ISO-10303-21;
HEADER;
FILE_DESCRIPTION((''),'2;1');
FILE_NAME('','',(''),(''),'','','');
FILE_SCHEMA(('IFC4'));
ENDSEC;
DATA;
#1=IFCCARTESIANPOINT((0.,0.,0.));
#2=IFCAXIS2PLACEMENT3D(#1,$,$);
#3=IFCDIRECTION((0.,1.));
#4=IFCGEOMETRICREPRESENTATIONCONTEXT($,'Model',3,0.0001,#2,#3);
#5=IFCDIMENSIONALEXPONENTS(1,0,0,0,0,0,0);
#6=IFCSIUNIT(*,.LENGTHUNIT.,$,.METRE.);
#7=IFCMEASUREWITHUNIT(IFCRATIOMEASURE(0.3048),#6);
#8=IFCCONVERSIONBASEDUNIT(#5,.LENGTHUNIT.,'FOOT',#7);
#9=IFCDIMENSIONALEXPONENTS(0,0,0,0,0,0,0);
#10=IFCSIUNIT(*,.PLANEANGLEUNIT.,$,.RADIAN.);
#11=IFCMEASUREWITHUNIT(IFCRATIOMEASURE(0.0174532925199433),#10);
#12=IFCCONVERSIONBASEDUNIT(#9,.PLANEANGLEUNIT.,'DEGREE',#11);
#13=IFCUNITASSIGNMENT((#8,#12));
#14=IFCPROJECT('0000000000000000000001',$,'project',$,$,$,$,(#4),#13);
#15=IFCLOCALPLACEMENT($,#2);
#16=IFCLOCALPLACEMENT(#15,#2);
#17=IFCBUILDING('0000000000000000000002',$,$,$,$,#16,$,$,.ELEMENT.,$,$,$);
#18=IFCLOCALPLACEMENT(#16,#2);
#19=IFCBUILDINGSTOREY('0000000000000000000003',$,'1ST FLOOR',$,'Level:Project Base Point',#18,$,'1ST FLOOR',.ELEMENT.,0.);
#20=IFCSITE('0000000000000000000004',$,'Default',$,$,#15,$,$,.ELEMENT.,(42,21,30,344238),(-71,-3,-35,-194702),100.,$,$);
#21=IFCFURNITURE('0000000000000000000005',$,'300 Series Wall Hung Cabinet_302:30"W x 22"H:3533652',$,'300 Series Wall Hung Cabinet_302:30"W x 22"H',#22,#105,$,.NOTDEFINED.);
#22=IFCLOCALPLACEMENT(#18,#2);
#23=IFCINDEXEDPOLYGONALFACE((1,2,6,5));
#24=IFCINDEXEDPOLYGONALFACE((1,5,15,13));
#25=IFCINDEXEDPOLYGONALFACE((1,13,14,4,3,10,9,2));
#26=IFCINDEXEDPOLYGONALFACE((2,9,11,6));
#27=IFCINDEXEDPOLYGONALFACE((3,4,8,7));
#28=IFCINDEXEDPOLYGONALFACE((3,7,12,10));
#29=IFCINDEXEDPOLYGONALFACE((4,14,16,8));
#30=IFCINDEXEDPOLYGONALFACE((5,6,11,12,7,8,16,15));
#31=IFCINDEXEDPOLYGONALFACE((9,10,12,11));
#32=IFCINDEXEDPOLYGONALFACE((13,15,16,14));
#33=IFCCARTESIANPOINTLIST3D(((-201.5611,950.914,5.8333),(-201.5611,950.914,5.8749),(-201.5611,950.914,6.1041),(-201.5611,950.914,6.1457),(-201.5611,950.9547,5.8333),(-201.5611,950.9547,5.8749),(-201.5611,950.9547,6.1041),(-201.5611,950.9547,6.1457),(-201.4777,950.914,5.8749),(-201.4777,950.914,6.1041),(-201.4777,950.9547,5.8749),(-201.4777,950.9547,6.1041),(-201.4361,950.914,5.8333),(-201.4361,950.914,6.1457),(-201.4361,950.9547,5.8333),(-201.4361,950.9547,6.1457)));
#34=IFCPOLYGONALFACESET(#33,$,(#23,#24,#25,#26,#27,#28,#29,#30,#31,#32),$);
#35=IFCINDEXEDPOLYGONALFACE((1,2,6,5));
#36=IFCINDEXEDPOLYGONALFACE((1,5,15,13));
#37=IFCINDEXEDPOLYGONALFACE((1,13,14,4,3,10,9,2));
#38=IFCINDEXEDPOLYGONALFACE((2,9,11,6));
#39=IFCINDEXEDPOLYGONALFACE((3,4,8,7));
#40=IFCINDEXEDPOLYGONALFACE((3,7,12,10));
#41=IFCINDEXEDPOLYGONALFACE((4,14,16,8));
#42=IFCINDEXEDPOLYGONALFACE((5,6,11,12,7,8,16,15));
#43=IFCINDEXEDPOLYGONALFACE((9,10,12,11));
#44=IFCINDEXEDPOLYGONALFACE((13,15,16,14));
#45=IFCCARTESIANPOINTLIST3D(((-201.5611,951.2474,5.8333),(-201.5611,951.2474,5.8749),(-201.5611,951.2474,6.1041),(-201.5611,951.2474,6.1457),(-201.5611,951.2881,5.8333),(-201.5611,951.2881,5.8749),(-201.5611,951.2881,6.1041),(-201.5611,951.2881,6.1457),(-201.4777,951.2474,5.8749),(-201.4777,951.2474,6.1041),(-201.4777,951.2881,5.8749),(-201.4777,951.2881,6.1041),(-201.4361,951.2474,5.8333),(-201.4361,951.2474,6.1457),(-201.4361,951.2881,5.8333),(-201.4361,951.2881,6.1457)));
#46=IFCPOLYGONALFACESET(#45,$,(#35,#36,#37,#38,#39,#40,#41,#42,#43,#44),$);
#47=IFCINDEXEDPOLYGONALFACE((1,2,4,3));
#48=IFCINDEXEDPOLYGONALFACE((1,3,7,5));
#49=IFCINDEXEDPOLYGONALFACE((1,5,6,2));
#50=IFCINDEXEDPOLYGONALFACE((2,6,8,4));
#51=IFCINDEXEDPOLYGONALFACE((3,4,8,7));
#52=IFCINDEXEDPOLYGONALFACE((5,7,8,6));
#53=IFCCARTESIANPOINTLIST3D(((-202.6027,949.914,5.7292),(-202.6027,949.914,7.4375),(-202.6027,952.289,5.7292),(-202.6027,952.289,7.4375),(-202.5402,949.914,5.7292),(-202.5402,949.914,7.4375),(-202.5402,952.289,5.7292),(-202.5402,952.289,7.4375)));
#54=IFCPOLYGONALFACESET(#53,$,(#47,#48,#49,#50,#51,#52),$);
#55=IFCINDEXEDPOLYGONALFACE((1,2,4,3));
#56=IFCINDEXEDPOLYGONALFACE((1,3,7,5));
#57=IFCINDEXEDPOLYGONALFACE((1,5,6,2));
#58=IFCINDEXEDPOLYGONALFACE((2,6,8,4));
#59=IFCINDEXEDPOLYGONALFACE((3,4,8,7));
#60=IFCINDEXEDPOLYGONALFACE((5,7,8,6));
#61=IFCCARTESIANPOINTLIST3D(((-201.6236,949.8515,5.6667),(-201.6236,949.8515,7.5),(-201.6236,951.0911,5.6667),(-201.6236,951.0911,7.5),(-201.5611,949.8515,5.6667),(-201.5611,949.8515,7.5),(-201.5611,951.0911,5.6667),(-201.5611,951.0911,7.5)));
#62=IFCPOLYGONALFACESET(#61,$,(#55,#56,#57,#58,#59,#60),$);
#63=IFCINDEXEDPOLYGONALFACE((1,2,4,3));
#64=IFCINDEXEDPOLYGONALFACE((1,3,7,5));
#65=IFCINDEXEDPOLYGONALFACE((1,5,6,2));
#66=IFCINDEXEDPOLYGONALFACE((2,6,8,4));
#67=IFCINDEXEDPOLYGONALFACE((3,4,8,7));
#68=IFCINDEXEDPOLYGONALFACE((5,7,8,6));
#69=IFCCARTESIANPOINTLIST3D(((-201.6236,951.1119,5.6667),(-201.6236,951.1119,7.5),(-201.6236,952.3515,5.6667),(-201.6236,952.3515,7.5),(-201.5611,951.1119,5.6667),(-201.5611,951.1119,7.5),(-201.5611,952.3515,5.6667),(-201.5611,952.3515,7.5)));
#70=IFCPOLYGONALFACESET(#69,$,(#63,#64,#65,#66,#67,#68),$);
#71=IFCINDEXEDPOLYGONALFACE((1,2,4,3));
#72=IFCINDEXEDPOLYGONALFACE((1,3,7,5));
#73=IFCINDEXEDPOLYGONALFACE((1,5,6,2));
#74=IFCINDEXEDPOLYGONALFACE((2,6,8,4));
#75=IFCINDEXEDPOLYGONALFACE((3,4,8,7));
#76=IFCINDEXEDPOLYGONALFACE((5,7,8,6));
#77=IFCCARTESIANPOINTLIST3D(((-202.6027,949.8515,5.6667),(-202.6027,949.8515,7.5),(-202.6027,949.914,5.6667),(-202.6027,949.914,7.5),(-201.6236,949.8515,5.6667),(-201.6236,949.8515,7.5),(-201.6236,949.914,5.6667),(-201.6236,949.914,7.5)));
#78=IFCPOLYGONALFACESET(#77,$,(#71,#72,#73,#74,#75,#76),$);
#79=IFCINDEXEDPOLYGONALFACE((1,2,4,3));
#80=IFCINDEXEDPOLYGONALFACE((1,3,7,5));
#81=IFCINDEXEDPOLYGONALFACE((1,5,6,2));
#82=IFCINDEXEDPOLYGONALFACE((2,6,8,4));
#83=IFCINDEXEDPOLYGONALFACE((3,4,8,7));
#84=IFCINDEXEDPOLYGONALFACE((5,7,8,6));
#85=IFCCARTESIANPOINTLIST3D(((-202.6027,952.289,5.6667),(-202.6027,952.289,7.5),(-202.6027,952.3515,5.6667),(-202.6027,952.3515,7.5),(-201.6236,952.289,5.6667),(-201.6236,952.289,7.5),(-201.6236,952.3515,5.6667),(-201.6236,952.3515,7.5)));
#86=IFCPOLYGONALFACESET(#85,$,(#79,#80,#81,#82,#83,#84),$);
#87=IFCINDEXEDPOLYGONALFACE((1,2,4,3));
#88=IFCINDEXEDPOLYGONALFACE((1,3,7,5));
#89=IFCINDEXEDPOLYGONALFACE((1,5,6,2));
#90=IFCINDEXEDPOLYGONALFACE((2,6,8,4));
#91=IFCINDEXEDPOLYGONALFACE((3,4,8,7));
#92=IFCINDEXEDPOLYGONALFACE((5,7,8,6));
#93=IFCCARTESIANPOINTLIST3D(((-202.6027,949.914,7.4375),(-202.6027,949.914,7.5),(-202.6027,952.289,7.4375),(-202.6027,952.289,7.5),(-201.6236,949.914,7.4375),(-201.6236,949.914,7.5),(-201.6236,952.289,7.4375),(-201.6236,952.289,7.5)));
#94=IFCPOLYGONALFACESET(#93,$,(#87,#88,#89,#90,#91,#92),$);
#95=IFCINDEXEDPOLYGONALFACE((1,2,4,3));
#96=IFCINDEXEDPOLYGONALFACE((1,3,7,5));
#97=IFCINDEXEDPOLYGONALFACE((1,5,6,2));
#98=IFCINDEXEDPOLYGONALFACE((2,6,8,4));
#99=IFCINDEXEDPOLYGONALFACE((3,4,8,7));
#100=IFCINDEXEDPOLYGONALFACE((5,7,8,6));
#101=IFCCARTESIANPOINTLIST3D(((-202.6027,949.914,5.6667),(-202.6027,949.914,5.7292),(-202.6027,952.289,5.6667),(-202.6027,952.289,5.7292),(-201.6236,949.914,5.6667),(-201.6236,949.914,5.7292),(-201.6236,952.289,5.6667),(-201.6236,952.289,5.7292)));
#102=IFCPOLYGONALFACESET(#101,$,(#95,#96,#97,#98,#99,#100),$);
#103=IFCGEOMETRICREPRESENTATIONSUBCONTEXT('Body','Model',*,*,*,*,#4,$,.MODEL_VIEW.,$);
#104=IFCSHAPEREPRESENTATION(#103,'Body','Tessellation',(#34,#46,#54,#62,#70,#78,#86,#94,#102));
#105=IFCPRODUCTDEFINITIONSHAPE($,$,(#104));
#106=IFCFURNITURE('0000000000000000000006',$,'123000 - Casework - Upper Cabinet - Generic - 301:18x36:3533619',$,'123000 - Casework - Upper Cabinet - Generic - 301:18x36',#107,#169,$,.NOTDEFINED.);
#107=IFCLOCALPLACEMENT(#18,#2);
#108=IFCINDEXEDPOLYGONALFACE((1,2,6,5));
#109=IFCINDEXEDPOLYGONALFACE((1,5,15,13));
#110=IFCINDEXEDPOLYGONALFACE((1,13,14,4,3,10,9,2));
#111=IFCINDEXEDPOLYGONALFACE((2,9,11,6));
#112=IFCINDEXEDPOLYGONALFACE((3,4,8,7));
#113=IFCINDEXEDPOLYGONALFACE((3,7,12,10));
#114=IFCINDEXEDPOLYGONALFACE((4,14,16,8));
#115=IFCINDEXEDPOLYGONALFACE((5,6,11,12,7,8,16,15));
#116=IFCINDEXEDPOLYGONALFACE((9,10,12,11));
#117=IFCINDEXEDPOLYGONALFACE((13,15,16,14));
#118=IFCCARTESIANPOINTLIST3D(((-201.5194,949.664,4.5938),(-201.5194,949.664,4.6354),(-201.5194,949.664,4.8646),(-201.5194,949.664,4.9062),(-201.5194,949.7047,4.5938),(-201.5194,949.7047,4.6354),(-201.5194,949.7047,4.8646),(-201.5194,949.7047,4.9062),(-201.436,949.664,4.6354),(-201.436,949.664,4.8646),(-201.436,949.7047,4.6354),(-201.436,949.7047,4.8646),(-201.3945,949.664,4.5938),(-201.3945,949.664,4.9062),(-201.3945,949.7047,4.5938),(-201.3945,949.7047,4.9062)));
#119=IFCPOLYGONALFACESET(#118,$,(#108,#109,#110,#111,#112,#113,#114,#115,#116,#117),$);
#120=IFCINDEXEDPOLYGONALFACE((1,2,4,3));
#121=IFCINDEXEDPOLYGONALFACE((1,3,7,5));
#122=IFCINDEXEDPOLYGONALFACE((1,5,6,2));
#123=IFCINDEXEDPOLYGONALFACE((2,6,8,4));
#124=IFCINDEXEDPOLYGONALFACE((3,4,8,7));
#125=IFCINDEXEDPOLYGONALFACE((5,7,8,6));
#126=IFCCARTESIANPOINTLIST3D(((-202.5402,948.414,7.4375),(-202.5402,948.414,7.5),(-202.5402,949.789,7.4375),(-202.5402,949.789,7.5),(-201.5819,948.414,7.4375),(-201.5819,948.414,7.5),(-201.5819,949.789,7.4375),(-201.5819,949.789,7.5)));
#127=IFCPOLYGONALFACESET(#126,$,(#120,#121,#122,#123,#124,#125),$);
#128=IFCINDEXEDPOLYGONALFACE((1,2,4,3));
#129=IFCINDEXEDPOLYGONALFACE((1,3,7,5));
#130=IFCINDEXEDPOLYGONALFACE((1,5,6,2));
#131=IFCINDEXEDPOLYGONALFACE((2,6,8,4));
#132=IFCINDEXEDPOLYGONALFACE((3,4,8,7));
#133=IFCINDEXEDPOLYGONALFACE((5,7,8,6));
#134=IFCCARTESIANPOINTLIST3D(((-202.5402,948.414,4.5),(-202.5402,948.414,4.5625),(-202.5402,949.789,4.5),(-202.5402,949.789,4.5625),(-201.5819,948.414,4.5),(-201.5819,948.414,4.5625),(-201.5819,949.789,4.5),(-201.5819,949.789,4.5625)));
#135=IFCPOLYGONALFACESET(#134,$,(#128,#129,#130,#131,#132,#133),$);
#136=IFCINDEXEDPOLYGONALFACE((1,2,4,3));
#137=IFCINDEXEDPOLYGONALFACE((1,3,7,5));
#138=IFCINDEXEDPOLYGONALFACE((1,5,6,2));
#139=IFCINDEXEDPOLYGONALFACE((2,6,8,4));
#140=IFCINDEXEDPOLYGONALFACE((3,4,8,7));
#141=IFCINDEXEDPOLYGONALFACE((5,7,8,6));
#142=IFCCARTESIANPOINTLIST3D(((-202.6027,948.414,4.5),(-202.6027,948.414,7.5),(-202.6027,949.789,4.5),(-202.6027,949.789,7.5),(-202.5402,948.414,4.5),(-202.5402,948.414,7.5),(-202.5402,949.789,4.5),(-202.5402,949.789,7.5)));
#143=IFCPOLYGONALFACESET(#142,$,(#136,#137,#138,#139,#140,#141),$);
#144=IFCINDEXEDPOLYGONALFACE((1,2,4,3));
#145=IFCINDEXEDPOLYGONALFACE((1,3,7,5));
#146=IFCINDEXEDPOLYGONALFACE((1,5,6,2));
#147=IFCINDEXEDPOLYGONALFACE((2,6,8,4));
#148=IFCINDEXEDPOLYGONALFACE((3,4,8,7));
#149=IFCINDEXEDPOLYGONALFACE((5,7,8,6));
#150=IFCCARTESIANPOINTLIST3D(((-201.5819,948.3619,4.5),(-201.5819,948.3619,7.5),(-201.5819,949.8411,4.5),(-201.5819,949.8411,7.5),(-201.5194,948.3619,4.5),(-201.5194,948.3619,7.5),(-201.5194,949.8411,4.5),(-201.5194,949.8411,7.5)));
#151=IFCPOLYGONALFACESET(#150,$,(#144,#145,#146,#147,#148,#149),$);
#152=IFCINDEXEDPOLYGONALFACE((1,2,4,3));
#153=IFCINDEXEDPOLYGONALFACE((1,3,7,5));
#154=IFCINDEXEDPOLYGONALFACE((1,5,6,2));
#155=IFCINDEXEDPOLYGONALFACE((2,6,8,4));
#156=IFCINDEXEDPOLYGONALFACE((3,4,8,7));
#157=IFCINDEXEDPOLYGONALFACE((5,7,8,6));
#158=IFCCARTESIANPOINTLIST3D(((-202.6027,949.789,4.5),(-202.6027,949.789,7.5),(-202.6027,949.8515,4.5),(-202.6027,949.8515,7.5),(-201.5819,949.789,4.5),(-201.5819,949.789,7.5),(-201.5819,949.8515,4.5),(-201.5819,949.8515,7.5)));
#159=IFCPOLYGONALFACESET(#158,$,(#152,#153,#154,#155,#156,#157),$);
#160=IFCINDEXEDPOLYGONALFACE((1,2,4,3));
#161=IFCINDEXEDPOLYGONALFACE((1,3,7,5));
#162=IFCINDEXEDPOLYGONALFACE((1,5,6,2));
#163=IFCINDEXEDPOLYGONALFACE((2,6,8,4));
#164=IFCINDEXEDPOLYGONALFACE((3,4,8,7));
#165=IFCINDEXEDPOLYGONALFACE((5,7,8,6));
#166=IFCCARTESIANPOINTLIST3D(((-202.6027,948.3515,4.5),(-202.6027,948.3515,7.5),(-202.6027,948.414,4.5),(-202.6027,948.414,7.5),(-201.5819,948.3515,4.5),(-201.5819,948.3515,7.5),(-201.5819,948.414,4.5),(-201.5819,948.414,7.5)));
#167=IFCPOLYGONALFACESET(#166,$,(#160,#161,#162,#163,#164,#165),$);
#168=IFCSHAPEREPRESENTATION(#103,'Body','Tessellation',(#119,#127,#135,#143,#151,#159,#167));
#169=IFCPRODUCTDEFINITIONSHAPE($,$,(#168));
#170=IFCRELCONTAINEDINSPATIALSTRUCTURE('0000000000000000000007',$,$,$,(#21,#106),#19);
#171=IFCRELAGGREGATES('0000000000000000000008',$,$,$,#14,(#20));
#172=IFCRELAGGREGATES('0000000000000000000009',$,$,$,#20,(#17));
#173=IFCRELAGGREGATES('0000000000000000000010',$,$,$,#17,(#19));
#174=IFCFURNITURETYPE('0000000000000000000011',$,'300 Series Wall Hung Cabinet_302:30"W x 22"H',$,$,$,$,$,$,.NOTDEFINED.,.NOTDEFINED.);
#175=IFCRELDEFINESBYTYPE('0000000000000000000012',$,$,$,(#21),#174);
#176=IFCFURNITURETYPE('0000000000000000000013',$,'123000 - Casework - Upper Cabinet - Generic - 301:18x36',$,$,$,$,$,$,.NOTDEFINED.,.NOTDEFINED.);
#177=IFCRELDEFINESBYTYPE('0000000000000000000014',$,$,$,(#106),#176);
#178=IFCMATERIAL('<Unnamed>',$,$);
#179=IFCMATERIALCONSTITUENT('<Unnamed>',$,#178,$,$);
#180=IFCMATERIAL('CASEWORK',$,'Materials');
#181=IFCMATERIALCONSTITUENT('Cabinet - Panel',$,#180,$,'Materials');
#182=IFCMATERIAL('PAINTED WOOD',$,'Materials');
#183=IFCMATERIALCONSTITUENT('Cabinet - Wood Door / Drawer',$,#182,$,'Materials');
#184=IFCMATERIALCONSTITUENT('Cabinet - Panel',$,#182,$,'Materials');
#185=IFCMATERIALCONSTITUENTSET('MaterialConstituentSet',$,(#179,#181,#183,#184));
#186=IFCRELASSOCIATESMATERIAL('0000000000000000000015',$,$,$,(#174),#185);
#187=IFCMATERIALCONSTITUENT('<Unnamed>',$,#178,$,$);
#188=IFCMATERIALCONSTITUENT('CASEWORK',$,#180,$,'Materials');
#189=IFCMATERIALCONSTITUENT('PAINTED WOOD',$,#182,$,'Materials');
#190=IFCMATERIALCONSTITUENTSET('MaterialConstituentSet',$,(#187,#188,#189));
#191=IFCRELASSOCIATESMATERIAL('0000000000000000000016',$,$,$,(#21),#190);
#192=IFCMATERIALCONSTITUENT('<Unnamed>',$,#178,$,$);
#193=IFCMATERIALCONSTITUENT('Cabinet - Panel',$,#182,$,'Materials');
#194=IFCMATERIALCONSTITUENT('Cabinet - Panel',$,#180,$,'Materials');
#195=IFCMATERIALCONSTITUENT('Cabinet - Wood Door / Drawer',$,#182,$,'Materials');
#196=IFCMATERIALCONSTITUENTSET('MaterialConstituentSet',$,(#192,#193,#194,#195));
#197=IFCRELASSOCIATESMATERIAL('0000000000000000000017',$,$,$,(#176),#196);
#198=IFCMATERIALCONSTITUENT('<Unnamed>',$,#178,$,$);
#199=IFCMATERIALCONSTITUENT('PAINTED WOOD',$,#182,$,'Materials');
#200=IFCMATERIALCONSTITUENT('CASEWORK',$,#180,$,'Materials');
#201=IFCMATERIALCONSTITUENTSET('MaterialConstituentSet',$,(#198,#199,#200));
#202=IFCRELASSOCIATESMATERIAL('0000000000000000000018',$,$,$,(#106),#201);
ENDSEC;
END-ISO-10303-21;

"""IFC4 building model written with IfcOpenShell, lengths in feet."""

from ifc_helpers import new_model, entity, si_unit, converted_unit, direction, frame, frame_2d, origin, origin_2d_with_axis, place, context, subcontext, project, spatial, polyline, rectangle, outline, extrude, source, transform, mapped, material, constituent, constituent_set, type_object, type_shapes, element, save


model = new_model("IFC4")

# Units and contexts
model_context = context("Model", 3, precision=0.0001, world=origin(), true_north=direction((0.0, 1.0)))
body_context = subcontext(model_context, "Body", "Model", "MODEL_VIEW")
ifc_project = project(units=[converted_unit("LENGTHUNIT", "FOOT", entity("IfcRatioMeasure", 0.3048), si_unit("LENGTHUNIT", "METRE"), dimensions=[1, 0, 0, 0, 0, 0, 0]), converted_unit("PLANEANGLEUNIT", "DEGREE", entity("IfcRatioMeasure", 0.0174532925199433), si_unit("PLANEANGLEUNIT", "RADIAN"), dimensions=[0, 0, 0, 0, 0, 0, 0])], contexts=[model_context])

# Site, building, storey
site_placement = place(None, origin())
site = spatial("IfcSite", under=ifc_project, at=site_placement, Name="Default", CompositionType="ELEMENT", RefLatitude=(42, 21, 30, 344238), RefLongitude=(-71, -3, -35, -194702), RefElevation=100.0)
building_placement = place(site_placement, origin())
building = spatial("IfcBuilding", under=site, at=building_placement, CompositionType="ELEMENT")
storey_placement = place(building_placement, origin())
storey = spatial("IfcBuildingStorey", under=building, at=storey_placement, Name="1ST FLOOR", ObjectType="Level:Project Base Point", LongName="1ST FLOOR", CompositionType="ELEMENT", Elevation=0.0)

# Shared definitions
ifc_material_1 = material(Name="<Unnamed>")

# Shared definitions
ifc_material_2 = material(Name="PAINTED WOOD", Category="Materials")
ifc_material_3 = material(Name="CASEWORK", Category="Materials")

# Furniture
ifc_constituent_1 = constituent(ifc_material_1, Name="<Unnamed>")
ifc_constituent_2 = constituent(ifc_material_3, Name="CASEWORK", Category="Materials")
ifc_constituent_3 = constituent(ifc_material_2, Name="PAINTED WOOD", Category="Materials")
ifc_constituent_set_1 = constituent_set(constituents=[ifc_constituent_1, ifc_constituent_2, ifc_constituent_3], Name="MaterialConstituentSet")
ifc_constituent_4 = constituent(ifc_material_1, Name="<Unnamed>")
ifc_constituent_5 = constituent(ifc_material_3, Name="Cabinet - Panel", Category="Materials")
ifc_constituent_6 = constituent(ifc_material_2, Name="Cabinet - Wood Door / Drawer", Category="Materials")
ifc_constituent_7 = constituent(ifc_material_2, Name="Cabinet - Panel", Category="Materials")
ifc_constituent_set_2 = constituent_set(constituents=[ifc_constituent_4, ifc_constituent_5, ifc_constituent_6, ifc_constituent_7], Name="MaterialConstituentSet")
furniture_type_1 = type_object("IfcFurnitureType", Name="300 Series Wall Hung Cabinet_302:30\"W x 22\"H", AssemblyPlace="NOTDEFINED", PredefinedType="NOTDEFINED", material=ifc_constituent_set_2)
shared_shape_1 = source(origin(), body_context, "Body", "SweptSolid", [
    extrude(outline(polyline([(0.1146, -0.0521), (0.1562, -0.0521), (0.1562, 0.0729), (-0.1562, 0.0729), (-0.1562, -0.0521), (-0.1146, -0.0521), (-0.1146, 0.0313), (0.1146, 0.0313), (0.1146, -0.0521)])), frame((1.0625, 0.0729, 0.3229), z_axis=(1.0, 0.0, 0.0), x_axis=(0.0, 0.0, 1.0)), (0.0, 0.0, 1.0), 0.0407),
    extrude(outline(polyline([(0.1146, -0.0521), (0.1562, -0.0521), (0.1562, 0.0729), (-0.1562, 0.0729), (-0.1562, -0.0521), (-0.1146, -0.0521), (-0.1146, 0.0313), (0.1146, 0.0313), (0.1146, -0.0521)])), frame((1.3958, 0.0729, 0.3229), z_axis=(1.0, 0.0, 0.0), x_axis=(0.0, 0.0, 1.0)), (0.0, 0.0, 1.0), 0.0407),
    extrude(rectangle(XDim=2.375, YDim=0.0625, at=origin_2d_with_axis()), frame((1.25, 1.1354, 0.0625), z_axis=(0.0, 0.0, 1.0), x_axis=(-1.0, 0.0, 0.0)), (0.0, 0.0, 1.0), 1.7083),
    extrude(rectangle(XDim=1.2396, YDim=0.0625, at=origin_2d_with_axis()), frame((0.6198, 0.1562, 0.0), z_axis=(0.0, 0.0, 1.0), x_axis=(-1.0, 0.0, 0.0)), (0.0, 0.0, 1.0), 1.8333),
    extrude(rectangle(XDim=1.2396, YDim=0.0625, at=frame_2d((0.0, 0.0), x_axis=(1.0, 0.0))), frame((1.8802, 0.1562, 0.0), z_axis=(0.0, 0.0, 1.0), x_axis=(-1.0, 0.0, 0.0)), (0.0, 0.0, 1.0), 1.8333),
    extrude(rectangle(XDim=0.9792, YDim=0.0625, at=frame_2d((0.0, 0.0), x_axis=(1.0, 0.0))), frame((0.0313, 0.677, 0.0), z_axis=(0.0, 0.0, 1.0), x_axis=(0.0, -1.0, 0.0)), (0.0, 0.0, 1.0), 1.8333),
    extrude(rectangle(XDim=0.9792, YDim=0.0625, at=frame_2d((0.0, 0.0), x_axis=(1.0, 0.0))), frame((2.4688, 0.677, 0.0), z_axis=(0.0, 0.0, 1.0), x_axis=(0.0, -1.0, 0.0)), (0.0, 0.0, 1.0), 1.8333),
    extrude(rectangle(XDim=0.9792, YDim=2.375, at=frame_2d((0.0, 0.0), x_axis=(1.0, 0.0))), frame((1.25, 0.677, 1.7708), z_axis=(0.0, 0.0, 1.0), x_axis=(0.0, 1.0, 0.0)), (0.0, 0.0, 1.0), 0.0625),
    extrude(rectangle(XDim=0.9792, YDim=2.375, at=frame_2d((0.0, 0.0), x_axis=(1.0, 0.0))), frame((1.25, 0.677, 0.0), z_axis=(0.0, 0.0, 1.0), x_axis=(0.0, 1.0, 0.0)), (0.0, 0.0, 1.0), 0.0625),
])
type_shapes(furniture_type_1, [shared_shape_1])
furniture_1_placement = place(storey_placement, frame((-201.4361, 949.8515, 5.6667), z_axis=(0.0, 0.0, 1.0), x_axis=(0.0, 1.0, 0.0)))
element("IfcFurniture", 1, at=furniture_1_placement, inside=storey, type_object=furniture_type_1, material=ifc_constituent_set_1, Name="300 Series Wall Hung Cabinet_302:30\"W x 22\"H:3533652", ObjectType="300 Series Wall Hung Cabinet_302:30\"W x 22\"H", PredefinedType="NOTDEFINED", context=body_context, shape_type="MappedRepresentation", body=[
    mapped(shared_shape_1, transform((0.0, 0.0, 0.0), scale=1.0)),
])
ifc_constituent_8 = constituent(ifc_material_1, Name="<Unnamed>")
ifc_constituent_9 = constituent(ifc_material_2, Name="PAINTED WOOD", Category="Materials")
ifc_constituent_10 = constituent(ifc_material_3, Name="CASEWORK", Category="Materials")
ifc_constituent_set_3 = constituent_set(constituents=[ifc_constituent_8, ifc_constituent_9, ifc_constituent_10], Name="MaterialConstituentSet")
ifc_constituent_11 = constituent(ifc_material_1, Name="<Unnamed>")
ifc_constituent_12 = constituent(ifc_material_2, Name="Cabinet - Panel", Category="Materials")
ifc_constituent_13 = constituent(ifc_material_3, Name="Cabinet - Panel", Category="Materials")
ifc_constituent_14 = constituent(ifc_material_2, Name="Cabinet - Wood Door / Drawer", Category="Materials")
ifc_constituent_set_4 = constituent_set(constituents=[ifc_constituent_11, ifc_constituent_12, ifc_constituent_13, ifc_constituent_14], Name="MaterialConstituentSet")
furniture_type_2 = type_object("IfcFurnitureType", Name="123000 - Casework - Upper Cabinet - Generic - 301:18x36", AssemblyPlace="NOTDEFINED", PredefinedType="NOTDEFINED", material=ifc_constituent_set_4)
shared_shape_2 = source(origin(), body_context, "Body", "SweptSolid", [
    extrude(outline(polyline([(-0.0521, -0.1146), (-0.0521, -0.1562), (0.0729, -0.1562), (0.0729, 0.1562), (-0.0521, 0.1562), (-0.0521, 0.1146), (0.0313, 0.1146), (0.0313, -0.1146), (-0.0521, -0.1146)])), frame((0.1468, 1.1354, 0.25), z_axis=(-1.0, 0.0, 0.0), x_axis=(0.0, 1.0, 0.0)), (0.0, 0.0, -1.0), 0.0407),
    extrude(rectangle(XDim=0.9583, YDim=1.375, at=frame_2d((0.0, 0.0), x_axis=(1.0, 0.0))), frame((0.75, 0.5417, 2.9375), z_axis=(0.0, 0.0, 1.0), x_axis=(0.0, 1.0, 0.0)), (0.0, 0.0, 1.0), 0.0625),
    extrude(rectangle(XDim=0.9583, YDim=1.375, at=frame_2d((0.0, 0.0), x_axis=(1.0, 0.0))), frame((0.75, 0.5417, 0.0), z_axis=(0.0, 0.0, 1.0), x_axis=(0.0, 1.0, 0.0)), (0.0, 0.0, 1.0), 0.0625),
    extrude(rectangle(XDim=1.375, YDim=0.0625, at=origin_2d_with_axis()), frame((0.75, 0.0313, 0.0), z_axis=(0.0, 0.0, 1.0), x_axis=(-1.0, 0.0, 0.0)), (0.0, 0.0, 1.0), 3.0),
    extrude(rectangle(XDim=1.4792, YDim=0.0625, at=origin_2d_with_axis()), frame((0.75, 1.0521, 0.0)), (0.0, 0.0, 1.0), 3.0),
    extrude(rectangle(XDim=1.0208, YDim=0.0625, at=origin_2d_with_axis()), frame((0.0312, 0.5104, 0.0), z_axis=(0.0, 0.0, 1.0), x_axis=(0.0, 1.0, 0.0)), (0.0, 0.0, 1.0), 3.0),
    extrude(rectangle(XDim=1.0208, YDim=0.0625, at=origin_2d_with_axis()), frame((1.4688, 0.5104, 0.0), z_axis=(0.0, 0.0, 1.0), x_axis=(0.0, 1.0, 0.0)), (0.0, 0.0, 1.0), 3.0),
])
type_shapes(furniture_type_2, [shared_shape_2])
furniture_2_placement = place(storey_placement, frame((-202.6027, 949.8515, 4.5), z_axis=(0.0, 0.0, 1.0), x_axis=(0.0, -1.0, 0.0)))
element("IfcFurniture", 2, at=furniture_2_placement, inside=storey, type_object=furniture_type_2, material=ifc_constituent_set_3, Name="123000 - Casework - Upper Cabinet - Generic - 301:18x36:3533619", ObjectType="123000 - Casework - Upper Cabinet - Generic - 301:18x36", PredefinedType="NOTDEFINED", context=body_context, shape_type="MappedRepresentation", body=[
    mapped(shared_shape_2, transform((0.0, 0.0, 0.0), scale=1.0)),
])

save(model, "model.ifc")
